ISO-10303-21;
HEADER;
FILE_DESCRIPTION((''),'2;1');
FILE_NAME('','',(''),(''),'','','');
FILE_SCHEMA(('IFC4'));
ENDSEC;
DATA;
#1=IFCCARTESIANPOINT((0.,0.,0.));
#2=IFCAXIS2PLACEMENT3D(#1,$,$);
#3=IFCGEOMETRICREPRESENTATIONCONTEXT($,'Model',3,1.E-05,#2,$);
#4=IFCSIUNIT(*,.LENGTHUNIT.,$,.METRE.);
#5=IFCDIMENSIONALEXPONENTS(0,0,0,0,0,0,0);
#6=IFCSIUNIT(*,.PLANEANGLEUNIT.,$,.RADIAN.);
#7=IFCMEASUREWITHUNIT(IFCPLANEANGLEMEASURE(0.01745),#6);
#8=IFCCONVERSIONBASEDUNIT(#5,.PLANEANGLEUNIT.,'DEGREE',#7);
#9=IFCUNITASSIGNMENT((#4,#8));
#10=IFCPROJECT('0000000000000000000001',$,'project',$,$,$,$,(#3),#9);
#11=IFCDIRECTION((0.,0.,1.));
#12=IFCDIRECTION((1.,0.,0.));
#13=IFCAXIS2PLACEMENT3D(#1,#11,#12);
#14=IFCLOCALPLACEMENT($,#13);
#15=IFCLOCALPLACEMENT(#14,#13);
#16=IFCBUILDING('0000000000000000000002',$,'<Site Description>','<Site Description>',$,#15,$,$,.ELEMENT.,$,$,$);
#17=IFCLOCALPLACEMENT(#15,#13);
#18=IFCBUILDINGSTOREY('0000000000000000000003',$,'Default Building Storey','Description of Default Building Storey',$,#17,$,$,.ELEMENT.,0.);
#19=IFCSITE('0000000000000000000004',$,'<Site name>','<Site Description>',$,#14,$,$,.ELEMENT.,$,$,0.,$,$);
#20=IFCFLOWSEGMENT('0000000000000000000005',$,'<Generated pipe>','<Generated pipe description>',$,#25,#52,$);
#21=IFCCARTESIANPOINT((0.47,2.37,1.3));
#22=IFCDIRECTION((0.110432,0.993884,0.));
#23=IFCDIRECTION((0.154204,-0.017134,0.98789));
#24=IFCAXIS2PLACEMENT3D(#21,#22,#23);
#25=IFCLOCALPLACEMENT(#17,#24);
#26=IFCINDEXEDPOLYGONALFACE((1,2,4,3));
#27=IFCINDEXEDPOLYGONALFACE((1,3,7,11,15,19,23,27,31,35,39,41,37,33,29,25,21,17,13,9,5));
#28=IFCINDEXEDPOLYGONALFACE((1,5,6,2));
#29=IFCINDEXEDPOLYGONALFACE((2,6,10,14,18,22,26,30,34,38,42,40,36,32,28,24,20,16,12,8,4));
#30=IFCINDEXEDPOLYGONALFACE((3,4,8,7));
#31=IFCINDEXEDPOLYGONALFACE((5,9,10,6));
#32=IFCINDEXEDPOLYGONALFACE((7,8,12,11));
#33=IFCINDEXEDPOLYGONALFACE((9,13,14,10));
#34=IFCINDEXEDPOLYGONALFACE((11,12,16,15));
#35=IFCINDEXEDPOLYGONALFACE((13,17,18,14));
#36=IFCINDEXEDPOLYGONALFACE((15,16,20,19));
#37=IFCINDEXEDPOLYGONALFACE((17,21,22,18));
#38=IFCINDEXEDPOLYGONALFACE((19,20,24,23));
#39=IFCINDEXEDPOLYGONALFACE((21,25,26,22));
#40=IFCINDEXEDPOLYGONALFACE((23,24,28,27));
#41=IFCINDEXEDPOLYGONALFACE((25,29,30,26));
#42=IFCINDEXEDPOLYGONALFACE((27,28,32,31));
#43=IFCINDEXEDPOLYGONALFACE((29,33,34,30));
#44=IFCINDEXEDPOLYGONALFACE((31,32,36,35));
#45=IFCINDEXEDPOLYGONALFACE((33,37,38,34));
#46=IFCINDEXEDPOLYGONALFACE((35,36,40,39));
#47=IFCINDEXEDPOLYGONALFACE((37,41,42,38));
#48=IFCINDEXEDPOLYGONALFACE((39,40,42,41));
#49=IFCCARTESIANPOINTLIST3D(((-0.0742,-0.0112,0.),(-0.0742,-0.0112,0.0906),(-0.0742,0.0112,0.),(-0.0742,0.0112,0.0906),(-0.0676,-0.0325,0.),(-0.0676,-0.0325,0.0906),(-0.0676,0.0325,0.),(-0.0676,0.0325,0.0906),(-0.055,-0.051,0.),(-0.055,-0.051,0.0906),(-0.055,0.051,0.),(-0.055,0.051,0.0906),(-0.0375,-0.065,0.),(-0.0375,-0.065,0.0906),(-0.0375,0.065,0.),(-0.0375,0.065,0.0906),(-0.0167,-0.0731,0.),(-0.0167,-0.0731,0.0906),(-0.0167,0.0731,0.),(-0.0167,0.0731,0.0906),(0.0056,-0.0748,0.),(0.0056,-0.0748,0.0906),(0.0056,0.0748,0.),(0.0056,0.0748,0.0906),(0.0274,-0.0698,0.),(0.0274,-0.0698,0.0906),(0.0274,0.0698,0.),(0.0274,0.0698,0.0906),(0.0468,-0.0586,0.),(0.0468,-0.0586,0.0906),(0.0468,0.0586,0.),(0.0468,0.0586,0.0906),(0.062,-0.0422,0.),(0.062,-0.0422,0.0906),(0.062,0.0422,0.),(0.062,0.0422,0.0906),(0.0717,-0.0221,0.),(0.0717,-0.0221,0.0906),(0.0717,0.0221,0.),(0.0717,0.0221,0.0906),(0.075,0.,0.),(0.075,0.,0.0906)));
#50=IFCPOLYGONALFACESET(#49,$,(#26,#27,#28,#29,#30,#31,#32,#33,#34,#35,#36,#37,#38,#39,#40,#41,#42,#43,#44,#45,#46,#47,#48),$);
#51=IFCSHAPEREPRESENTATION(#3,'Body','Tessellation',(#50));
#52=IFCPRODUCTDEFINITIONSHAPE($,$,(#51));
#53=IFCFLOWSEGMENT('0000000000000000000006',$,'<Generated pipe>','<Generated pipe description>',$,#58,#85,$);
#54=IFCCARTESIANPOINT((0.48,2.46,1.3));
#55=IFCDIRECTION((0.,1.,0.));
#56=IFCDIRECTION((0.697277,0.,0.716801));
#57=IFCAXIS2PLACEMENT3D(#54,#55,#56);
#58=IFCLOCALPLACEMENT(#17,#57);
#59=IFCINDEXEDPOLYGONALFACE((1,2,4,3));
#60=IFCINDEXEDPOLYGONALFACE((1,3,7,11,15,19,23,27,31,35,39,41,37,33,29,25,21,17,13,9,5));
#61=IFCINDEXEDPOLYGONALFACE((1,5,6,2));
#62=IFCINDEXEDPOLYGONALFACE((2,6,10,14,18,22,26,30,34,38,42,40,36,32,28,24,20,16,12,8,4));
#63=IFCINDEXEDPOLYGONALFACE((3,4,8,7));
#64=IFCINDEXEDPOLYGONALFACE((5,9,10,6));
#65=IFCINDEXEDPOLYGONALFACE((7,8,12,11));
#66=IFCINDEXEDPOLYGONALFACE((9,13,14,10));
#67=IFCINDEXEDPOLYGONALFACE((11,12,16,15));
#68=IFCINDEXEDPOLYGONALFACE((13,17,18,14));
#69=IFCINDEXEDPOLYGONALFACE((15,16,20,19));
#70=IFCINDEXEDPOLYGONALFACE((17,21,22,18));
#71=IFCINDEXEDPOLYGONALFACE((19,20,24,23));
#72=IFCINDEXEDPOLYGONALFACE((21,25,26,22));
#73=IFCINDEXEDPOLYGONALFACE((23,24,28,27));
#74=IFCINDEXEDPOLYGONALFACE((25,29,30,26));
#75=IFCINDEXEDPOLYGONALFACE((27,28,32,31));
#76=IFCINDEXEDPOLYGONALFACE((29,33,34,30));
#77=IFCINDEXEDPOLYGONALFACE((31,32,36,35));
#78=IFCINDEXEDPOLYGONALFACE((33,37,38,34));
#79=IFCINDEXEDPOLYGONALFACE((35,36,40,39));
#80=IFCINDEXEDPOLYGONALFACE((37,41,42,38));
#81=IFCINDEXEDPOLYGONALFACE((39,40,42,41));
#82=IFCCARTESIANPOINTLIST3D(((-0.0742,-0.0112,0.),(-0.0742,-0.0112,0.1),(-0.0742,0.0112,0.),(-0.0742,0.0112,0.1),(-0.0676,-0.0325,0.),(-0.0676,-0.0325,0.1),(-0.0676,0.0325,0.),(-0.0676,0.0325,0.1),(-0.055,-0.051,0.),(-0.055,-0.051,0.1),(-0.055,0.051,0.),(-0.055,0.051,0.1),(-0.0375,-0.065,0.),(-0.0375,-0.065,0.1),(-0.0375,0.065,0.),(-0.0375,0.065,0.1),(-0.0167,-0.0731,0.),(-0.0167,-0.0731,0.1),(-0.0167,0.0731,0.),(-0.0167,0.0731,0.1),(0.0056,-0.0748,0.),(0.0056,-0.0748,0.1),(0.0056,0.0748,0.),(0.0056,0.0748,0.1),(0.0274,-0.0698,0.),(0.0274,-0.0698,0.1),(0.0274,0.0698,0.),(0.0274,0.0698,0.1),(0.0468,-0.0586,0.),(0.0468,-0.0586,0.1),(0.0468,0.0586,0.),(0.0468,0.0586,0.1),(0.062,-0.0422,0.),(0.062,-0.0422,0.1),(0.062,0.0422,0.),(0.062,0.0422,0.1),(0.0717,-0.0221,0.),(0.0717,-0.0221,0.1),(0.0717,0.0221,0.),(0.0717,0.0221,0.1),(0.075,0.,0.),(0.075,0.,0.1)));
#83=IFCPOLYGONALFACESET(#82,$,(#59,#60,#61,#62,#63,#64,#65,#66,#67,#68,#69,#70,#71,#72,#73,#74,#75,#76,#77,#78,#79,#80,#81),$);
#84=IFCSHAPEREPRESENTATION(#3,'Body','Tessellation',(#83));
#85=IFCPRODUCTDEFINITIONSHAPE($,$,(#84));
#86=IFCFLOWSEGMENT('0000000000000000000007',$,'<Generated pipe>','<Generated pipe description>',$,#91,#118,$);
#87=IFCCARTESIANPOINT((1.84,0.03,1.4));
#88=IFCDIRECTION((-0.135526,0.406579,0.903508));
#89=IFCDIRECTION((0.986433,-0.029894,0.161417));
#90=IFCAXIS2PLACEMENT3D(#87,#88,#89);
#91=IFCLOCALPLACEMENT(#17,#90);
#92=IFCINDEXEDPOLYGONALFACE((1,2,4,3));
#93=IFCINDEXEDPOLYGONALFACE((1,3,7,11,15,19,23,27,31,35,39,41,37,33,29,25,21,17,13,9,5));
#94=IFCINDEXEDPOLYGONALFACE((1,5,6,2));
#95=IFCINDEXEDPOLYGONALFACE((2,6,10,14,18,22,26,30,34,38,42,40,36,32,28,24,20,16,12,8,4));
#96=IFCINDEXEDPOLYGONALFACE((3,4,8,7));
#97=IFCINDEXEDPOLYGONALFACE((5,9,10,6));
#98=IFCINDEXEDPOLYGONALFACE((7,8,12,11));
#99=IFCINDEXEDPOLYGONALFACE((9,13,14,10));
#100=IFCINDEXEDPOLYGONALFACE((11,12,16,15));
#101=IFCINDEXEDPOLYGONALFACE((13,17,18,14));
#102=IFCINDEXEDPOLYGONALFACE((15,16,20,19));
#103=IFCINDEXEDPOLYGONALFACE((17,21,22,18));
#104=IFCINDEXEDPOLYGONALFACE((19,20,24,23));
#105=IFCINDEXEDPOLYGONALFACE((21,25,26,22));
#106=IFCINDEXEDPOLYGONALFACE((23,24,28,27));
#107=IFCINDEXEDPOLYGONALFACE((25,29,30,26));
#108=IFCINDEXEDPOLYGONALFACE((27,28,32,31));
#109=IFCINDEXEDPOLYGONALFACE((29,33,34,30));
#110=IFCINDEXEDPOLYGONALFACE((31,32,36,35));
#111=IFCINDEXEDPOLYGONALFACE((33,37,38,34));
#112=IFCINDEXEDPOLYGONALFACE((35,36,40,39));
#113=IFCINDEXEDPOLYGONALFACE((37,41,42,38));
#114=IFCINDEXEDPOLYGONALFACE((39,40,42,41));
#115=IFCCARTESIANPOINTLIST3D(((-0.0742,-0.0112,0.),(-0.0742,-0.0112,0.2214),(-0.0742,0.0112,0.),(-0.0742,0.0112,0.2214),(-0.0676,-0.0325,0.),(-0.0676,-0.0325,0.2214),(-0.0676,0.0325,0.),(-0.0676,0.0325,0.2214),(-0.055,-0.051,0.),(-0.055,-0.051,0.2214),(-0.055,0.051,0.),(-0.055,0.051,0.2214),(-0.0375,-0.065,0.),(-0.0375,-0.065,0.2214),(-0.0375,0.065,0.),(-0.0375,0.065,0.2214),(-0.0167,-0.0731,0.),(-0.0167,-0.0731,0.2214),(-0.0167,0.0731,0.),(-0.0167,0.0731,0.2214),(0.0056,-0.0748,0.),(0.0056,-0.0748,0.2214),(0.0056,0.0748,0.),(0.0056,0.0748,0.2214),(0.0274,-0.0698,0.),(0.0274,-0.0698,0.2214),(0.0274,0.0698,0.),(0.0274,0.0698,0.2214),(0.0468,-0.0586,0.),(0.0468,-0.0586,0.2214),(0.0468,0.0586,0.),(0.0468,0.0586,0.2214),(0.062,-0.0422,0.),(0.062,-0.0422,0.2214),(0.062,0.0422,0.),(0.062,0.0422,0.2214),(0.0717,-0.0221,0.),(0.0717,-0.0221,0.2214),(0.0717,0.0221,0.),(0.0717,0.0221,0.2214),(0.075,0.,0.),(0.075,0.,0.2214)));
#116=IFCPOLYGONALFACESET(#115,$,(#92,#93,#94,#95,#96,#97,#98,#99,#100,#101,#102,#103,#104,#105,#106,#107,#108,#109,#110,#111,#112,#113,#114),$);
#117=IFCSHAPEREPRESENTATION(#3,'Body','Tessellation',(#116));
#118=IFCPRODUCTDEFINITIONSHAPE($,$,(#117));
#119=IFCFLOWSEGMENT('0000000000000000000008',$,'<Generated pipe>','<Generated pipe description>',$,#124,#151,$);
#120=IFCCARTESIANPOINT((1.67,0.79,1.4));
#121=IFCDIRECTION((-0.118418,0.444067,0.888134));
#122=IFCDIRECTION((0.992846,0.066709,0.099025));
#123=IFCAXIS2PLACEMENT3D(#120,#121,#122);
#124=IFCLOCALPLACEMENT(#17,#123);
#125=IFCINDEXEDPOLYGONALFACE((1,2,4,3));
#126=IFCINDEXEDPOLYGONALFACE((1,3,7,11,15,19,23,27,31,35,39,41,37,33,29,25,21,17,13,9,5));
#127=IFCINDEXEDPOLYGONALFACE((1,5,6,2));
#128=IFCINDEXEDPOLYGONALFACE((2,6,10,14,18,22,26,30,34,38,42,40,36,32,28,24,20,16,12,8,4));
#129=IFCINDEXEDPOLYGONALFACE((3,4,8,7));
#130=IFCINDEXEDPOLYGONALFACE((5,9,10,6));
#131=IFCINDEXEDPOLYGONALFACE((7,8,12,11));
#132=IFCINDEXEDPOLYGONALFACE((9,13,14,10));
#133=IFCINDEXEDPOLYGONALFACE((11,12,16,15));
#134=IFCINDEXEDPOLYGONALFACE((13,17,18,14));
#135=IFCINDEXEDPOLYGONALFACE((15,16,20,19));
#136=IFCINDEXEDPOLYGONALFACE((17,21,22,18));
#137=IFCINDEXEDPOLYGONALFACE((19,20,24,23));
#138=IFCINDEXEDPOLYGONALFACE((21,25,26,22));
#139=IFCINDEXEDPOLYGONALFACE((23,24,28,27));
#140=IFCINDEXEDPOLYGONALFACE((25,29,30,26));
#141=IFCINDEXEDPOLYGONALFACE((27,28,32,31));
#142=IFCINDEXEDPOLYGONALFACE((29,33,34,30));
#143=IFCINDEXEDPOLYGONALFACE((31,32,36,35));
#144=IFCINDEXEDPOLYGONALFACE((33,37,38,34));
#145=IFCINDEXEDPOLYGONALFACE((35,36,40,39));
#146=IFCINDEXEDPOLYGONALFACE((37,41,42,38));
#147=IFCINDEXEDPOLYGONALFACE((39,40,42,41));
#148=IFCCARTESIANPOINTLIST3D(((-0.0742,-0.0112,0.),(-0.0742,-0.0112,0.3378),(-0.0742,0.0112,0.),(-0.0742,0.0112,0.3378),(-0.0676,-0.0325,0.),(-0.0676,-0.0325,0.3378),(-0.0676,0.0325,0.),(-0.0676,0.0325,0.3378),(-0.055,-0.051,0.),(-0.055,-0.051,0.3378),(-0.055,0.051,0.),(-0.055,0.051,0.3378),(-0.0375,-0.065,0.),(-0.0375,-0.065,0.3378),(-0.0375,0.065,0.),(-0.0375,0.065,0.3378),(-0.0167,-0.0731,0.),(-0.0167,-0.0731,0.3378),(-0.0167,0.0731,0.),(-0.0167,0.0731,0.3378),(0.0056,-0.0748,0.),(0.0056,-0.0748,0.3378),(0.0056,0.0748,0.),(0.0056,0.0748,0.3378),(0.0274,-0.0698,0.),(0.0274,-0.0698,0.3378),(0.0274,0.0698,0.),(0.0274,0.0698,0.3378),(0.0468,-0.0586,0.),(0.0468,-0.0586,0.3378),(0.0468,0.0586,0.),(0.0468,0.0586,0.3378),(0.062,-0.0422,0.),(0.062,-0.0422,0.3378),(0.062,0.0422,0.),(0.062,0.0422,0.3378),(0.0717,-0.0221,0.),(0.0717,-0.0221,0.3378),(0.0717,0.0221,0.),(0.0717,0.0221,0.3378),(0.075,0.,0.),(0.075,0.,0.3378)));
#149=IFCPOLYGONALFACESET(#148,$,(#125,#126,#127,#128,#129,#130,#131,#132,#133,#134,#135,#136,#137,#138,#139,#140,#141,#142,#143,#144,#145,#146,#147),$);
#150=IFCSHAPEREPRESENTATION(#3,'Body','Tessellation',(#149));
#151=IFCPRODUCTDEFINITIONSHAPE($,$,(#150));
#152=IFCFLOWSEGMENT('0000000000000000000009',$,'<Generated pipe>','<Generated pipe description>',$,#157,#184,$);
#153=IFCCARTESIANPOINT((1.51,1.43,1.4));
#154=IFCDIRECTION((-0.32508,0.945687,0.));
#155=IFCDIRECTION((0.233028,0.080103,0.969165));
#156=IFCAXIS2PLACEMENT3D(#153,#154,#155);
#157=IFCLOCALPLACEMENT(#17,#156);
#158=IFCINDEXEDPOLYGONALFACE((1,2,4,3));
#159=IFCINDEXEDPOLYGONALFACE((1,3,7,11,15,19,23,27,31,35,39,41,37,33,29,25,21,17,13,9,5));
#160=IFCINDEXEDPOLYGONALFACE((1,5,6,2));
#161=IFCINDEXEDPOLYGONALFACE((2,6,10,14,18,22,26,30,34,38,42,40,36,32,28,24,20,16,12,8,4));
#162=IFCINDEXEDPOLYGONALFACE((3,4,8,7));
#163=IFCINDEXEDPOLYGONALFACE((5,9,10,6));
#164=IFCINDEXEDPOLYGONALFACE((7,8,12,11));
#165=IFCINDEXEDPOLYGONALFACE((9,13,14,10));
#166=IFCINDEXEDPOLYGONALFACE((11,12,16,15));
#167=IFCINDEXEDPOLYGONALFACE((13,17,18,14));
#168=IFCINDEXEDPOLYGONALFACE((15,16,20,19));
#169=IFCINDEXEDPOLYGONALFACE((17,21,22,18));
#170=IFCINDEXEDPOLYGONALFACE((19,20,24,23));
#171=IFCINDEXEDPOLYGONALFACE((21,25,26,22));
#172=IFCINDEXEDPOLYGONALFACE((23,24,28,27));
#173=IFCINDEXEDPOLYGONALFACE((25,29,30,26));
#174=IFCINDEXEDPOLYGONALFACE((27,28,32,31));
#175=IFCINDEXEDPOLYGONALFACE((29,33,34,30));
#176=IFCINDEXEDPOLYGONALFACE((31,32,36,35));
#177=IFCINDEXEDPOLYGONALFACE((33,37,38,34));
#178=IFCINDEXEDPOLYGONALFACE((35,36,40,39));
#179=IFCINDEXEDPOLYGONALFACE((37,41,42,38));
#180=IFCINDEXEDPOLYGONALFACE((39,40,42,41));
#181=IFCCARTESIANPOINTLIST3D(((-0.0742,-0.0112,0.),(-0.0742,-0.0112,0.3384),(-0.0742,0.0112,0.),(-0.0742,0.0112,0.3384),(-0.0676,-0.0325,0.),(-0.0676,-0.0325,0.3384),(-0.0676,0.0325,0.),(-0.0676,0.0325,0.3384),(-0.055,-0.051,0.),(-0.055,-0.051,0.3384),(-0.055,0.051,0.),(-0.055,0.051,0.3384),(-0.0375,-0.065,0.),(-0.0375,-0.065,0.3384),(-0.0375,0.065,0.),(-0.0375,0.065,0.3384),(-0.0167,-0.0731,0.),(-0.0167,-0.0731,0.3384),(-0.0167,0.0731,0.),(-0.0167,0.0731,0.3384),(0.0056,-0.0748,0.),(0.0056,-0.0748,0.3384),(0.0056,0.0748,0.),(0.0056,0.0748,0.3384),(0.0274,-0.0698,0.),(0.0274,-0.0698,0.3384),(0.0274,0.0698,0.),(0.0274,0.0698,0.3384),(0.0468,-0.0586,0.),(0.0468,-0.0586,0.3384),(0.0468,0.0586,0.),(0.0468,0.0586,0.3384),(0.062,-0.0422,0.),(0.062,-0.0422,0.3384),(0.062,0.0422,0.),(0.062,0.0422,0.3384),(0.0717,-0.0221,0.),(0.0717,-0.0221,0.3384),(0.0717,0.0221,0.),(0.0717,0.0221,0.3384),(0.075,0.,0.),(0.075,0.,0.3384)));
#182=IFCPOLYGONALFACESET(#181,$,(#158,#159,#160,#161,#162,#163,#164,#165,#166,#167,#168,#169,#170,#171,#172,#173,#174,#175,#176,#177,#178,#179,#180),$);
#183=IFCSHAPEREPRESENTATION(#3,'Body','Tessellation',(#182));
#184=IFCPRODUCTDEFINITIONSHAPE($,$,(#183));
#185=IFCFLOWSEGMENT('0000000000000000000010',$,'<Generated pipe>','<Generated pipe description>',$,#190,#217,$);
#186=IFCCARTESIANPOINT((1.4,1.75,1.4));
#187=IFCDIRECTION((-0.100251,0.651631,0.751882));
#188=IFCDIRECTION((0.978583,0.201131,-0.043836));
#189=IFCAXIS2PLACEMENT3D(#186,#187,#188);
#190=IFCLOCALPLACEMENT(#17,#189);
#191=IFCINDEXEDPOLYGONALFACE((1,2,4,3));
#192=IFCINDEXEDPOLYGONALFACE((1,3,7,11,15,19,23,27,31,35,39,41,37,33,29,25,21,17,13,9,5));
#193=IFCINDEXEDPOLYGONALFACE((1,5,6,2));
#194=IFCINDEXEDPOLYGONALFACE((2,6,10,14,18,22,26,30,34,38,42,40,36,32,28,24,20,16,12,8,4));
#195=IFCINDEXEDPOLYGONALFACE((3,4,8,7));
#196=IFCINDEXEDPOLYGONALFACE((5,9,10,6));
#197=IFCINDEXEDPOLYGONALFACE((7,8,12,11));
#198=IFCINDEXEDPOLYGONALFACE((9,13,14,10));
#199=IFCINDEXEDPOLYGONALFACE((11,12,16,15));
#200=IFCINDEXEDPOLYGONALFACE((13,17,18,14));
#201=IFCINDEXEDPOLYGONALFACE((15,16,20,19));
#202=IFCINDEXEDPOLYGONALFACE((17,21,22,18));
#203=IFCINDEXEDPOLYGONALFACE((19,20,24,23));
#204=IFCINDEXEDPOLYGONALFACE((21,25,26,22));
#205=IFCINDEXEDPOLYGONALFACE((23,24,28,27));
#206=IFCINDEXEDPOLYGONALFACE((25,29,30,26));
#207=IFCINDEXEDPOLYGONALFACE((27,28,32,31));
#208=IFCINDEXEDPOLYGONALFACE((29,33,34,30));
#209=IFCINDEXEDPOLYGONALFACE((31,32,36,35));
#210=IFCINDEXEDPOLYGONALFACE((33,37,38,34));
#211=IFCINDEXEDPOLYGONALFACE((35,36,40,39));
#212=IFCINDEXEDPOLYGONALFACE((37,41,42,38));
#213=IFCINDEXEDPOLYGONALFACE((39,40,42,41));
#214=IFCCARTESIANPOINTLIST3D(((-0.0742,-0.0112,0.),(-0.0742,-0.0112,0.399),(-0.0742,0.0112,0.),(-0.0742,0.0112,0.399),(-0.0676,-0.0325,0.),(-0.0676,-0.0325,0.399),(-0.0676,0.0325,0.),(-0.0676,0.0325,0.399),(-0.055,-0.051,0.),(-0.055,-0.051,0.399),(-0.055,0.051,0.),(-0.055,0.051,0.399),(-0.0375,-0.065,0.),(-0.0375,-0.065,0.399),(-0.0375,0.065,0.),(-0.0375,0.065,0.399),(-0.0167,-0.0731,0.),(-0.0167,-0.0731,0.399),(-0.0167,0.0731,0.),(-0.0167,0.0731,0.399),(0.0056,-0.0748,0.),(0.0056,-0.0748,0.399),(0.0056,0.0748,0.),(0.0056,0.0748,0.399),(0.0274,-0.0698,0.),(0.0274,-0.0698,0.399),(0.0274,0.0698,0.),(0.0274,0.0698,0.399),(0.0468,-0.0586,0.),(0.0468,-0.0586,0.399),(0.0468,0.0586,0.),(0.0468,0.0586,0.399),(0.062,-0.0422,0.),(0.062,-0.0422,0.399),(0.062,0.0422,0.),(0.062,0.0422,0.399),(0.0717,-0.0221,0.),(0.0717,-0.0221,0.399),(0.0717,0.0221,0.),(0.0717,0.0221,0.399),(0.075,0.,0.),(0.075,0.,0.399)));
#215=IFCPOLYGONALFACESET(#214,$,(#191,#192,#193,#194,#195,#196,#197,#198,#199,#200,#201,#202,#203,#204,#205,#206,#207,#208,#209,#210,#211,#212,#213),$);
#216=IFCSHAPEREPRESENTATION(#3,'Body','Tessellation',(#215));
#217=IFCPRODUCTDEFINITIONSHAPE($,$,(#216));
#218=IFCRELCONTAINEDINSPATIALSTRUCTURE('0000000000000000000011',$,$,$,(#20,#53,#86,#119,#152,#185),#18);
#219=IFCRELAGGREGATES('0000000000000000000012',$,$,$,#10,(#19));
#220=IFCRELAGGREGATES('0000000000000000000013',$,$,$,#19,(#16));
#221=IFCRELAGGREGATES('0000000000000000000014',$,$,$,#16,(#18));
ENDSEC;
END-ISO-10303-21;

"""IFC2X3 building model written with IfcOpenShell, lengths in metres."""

from ifc_helpers import new_model, entity, si_unit, converted_unit, frame, origin, origin_with_axes, origin_2d_with_axis, place, context, project, spatial, circle, extrude, element, save


model = new_model("IFC2X3")

# Units and contexts
model_context = context("Model", 3, precision=1e-05, world=origin())
ifc_project = project(units=[si_unit("LENGTHUNIT", "METRE"), converted_unit("PLANEANGLEUNIT", "DEGREE", entity("IfcPlaneAngleMeasure", 0.01745), si_unit("PLANEANGLEUNIT", "RADIAN"), dimensions=[0, 0, 0, 0, 0, 0, 0])], contexts=[model_context])

# Site, building, storey
site_placement = place(None, origin_with_axes())
site = spatial("IfcSite", under=ifc_project, at=site_placement, Name="<Site name>", Description="<Site Description>", CompositionType="ELEMENT", RefElevation=0.0)
building_placement = place(site_placement, origin_with_axes())
building = spatial("IfcBuilding", under=site, at=building_placement, Name="<Site Description>", Description="<Site Description>", CompositionType="ELEMENT")
storey_placement = place(building_placement, origin_with_axes())
storey = spatial("IfcBuildingStorey", under=building, at=storey_placement, Name="Default Building Storey", Description="Description of Default Building Storey", CompositionType="ELEMENT", Elevation=0.0)

# Flow segments
flow_segment_1_placement = place(storey_placement, frame((0.47, 2.37, 1.3), z_axis=(0.110432, 0.993884, 0.0), x_axis=(0.154204, -0.017134, 0.98789)))
element("IfcFlowSegment", 1, at=flow_segment_1_placement, inside=storey, Name="<Generated pipe>", Description="<Generated pipe description>", context=model_context, shape_type="SweptSolid", body=[
    extrude(circle(Radius=0.075, at=origin_2d_with_axis()), origin_with_axes(), (0.0, 0.0, 1.0), 0.0906),
])
flow_segment_2_placement = place(storey_placement, frame((0.48, 2.46, 1.3), z_axis=(0.0, 1.0, 0.0), x_axis=(0.697277, 0.0, 0.716801)))
element("IfcFlowSegment", 2, at=flow_segment_2_placement, inside=storey, Name="<Generated pipe>", Description="<Generated pipe description>", context=model_context, shape_type="SweptSolid", body=[
    extrude(circle(Radius=0.075, at=origin_2d_with_axis()), origin_with_axes(), (0.0, 0.0, 1.0), 0.1),
])
flow_segment_3_placement = place(storey_placement, frame((1.84, 0.03, 1.4), z_axis=(-0.135526, 0.406579, 0.903508), x_axis=(0.986433, -0.029894, 0.161417)))
element("IfcFlowSegment", 3, at=flow_segment_3_placement, inside=storey, Name="<Generated pipe>", Description="<Generated pipe description>", context=model_context, shape_type="SweptSolid", body=[
    extrude(circle(Radius=0.075, at=origin_2d_with_axis()), origin_with_axes(), (0.0, 0.0, 1.0), 0.2214),
])
flow_segment_4_placement = place(storey_placement, frame((1.67, 0.79, 1.4), z_axis=(-0.118418, 0.444067, 0.888134), x_axis=(0.992846, 0.066709, 0.099025)))
element("IfcFlowSegment", 4, at=flow_segment_4_placement, inside=storey, Name="<Generated pipe>", Description="<Generated pipe description>", context=model_context, shape_type="SweptSolid", body=[
    extrude(circle(Radius=0.075, at=origin_2d_with_axis()), origin_with_axes(), (0.0, 0.0, 1.0), 0.3378),
])
flow_segment_5_placement = place(storey_placement, frame((1.51, 1.43, 1.4), z_axis=(-0.32508, 0.945687, 0.0), x_axis=(0.233028, 0.080103, 0.969165)))
element("IfcFlowSegment", 5, at=flow_segment_5_placement, inside=storey, Name="<Generated pipe>", Description="<Generated pipe description>", context=model_context, shape_type="SweptSolid", body=[
    extrude(circle(Radius=0.075, at=origin_2d_with_axis()), origin_with_axes(), (0.0, 0.0, 1.0), 0.3384),
])
flow_segment_6_placement = place(storey_placement, frame((1.4, 1.75, 1.4), z_axis=(-0.100251, 0.651631, 0.751882), x_axis=(0.978583, 0.201131, -0.043836)))
element("IfcFlowSegment", 6, at=flow_segment_6_placement, inside=storey, Name="<Generated pipe>", Description="<Generated pipe description>", context=model_context, shape_type="SweptSolid", body=[
    extrude(circle(Radius=0.075, at=origin_2d_with_axis()), origin_with_axes(), (0.0, 0.0, 1.0), 0.399),
])

save(model, "model.ifc")
